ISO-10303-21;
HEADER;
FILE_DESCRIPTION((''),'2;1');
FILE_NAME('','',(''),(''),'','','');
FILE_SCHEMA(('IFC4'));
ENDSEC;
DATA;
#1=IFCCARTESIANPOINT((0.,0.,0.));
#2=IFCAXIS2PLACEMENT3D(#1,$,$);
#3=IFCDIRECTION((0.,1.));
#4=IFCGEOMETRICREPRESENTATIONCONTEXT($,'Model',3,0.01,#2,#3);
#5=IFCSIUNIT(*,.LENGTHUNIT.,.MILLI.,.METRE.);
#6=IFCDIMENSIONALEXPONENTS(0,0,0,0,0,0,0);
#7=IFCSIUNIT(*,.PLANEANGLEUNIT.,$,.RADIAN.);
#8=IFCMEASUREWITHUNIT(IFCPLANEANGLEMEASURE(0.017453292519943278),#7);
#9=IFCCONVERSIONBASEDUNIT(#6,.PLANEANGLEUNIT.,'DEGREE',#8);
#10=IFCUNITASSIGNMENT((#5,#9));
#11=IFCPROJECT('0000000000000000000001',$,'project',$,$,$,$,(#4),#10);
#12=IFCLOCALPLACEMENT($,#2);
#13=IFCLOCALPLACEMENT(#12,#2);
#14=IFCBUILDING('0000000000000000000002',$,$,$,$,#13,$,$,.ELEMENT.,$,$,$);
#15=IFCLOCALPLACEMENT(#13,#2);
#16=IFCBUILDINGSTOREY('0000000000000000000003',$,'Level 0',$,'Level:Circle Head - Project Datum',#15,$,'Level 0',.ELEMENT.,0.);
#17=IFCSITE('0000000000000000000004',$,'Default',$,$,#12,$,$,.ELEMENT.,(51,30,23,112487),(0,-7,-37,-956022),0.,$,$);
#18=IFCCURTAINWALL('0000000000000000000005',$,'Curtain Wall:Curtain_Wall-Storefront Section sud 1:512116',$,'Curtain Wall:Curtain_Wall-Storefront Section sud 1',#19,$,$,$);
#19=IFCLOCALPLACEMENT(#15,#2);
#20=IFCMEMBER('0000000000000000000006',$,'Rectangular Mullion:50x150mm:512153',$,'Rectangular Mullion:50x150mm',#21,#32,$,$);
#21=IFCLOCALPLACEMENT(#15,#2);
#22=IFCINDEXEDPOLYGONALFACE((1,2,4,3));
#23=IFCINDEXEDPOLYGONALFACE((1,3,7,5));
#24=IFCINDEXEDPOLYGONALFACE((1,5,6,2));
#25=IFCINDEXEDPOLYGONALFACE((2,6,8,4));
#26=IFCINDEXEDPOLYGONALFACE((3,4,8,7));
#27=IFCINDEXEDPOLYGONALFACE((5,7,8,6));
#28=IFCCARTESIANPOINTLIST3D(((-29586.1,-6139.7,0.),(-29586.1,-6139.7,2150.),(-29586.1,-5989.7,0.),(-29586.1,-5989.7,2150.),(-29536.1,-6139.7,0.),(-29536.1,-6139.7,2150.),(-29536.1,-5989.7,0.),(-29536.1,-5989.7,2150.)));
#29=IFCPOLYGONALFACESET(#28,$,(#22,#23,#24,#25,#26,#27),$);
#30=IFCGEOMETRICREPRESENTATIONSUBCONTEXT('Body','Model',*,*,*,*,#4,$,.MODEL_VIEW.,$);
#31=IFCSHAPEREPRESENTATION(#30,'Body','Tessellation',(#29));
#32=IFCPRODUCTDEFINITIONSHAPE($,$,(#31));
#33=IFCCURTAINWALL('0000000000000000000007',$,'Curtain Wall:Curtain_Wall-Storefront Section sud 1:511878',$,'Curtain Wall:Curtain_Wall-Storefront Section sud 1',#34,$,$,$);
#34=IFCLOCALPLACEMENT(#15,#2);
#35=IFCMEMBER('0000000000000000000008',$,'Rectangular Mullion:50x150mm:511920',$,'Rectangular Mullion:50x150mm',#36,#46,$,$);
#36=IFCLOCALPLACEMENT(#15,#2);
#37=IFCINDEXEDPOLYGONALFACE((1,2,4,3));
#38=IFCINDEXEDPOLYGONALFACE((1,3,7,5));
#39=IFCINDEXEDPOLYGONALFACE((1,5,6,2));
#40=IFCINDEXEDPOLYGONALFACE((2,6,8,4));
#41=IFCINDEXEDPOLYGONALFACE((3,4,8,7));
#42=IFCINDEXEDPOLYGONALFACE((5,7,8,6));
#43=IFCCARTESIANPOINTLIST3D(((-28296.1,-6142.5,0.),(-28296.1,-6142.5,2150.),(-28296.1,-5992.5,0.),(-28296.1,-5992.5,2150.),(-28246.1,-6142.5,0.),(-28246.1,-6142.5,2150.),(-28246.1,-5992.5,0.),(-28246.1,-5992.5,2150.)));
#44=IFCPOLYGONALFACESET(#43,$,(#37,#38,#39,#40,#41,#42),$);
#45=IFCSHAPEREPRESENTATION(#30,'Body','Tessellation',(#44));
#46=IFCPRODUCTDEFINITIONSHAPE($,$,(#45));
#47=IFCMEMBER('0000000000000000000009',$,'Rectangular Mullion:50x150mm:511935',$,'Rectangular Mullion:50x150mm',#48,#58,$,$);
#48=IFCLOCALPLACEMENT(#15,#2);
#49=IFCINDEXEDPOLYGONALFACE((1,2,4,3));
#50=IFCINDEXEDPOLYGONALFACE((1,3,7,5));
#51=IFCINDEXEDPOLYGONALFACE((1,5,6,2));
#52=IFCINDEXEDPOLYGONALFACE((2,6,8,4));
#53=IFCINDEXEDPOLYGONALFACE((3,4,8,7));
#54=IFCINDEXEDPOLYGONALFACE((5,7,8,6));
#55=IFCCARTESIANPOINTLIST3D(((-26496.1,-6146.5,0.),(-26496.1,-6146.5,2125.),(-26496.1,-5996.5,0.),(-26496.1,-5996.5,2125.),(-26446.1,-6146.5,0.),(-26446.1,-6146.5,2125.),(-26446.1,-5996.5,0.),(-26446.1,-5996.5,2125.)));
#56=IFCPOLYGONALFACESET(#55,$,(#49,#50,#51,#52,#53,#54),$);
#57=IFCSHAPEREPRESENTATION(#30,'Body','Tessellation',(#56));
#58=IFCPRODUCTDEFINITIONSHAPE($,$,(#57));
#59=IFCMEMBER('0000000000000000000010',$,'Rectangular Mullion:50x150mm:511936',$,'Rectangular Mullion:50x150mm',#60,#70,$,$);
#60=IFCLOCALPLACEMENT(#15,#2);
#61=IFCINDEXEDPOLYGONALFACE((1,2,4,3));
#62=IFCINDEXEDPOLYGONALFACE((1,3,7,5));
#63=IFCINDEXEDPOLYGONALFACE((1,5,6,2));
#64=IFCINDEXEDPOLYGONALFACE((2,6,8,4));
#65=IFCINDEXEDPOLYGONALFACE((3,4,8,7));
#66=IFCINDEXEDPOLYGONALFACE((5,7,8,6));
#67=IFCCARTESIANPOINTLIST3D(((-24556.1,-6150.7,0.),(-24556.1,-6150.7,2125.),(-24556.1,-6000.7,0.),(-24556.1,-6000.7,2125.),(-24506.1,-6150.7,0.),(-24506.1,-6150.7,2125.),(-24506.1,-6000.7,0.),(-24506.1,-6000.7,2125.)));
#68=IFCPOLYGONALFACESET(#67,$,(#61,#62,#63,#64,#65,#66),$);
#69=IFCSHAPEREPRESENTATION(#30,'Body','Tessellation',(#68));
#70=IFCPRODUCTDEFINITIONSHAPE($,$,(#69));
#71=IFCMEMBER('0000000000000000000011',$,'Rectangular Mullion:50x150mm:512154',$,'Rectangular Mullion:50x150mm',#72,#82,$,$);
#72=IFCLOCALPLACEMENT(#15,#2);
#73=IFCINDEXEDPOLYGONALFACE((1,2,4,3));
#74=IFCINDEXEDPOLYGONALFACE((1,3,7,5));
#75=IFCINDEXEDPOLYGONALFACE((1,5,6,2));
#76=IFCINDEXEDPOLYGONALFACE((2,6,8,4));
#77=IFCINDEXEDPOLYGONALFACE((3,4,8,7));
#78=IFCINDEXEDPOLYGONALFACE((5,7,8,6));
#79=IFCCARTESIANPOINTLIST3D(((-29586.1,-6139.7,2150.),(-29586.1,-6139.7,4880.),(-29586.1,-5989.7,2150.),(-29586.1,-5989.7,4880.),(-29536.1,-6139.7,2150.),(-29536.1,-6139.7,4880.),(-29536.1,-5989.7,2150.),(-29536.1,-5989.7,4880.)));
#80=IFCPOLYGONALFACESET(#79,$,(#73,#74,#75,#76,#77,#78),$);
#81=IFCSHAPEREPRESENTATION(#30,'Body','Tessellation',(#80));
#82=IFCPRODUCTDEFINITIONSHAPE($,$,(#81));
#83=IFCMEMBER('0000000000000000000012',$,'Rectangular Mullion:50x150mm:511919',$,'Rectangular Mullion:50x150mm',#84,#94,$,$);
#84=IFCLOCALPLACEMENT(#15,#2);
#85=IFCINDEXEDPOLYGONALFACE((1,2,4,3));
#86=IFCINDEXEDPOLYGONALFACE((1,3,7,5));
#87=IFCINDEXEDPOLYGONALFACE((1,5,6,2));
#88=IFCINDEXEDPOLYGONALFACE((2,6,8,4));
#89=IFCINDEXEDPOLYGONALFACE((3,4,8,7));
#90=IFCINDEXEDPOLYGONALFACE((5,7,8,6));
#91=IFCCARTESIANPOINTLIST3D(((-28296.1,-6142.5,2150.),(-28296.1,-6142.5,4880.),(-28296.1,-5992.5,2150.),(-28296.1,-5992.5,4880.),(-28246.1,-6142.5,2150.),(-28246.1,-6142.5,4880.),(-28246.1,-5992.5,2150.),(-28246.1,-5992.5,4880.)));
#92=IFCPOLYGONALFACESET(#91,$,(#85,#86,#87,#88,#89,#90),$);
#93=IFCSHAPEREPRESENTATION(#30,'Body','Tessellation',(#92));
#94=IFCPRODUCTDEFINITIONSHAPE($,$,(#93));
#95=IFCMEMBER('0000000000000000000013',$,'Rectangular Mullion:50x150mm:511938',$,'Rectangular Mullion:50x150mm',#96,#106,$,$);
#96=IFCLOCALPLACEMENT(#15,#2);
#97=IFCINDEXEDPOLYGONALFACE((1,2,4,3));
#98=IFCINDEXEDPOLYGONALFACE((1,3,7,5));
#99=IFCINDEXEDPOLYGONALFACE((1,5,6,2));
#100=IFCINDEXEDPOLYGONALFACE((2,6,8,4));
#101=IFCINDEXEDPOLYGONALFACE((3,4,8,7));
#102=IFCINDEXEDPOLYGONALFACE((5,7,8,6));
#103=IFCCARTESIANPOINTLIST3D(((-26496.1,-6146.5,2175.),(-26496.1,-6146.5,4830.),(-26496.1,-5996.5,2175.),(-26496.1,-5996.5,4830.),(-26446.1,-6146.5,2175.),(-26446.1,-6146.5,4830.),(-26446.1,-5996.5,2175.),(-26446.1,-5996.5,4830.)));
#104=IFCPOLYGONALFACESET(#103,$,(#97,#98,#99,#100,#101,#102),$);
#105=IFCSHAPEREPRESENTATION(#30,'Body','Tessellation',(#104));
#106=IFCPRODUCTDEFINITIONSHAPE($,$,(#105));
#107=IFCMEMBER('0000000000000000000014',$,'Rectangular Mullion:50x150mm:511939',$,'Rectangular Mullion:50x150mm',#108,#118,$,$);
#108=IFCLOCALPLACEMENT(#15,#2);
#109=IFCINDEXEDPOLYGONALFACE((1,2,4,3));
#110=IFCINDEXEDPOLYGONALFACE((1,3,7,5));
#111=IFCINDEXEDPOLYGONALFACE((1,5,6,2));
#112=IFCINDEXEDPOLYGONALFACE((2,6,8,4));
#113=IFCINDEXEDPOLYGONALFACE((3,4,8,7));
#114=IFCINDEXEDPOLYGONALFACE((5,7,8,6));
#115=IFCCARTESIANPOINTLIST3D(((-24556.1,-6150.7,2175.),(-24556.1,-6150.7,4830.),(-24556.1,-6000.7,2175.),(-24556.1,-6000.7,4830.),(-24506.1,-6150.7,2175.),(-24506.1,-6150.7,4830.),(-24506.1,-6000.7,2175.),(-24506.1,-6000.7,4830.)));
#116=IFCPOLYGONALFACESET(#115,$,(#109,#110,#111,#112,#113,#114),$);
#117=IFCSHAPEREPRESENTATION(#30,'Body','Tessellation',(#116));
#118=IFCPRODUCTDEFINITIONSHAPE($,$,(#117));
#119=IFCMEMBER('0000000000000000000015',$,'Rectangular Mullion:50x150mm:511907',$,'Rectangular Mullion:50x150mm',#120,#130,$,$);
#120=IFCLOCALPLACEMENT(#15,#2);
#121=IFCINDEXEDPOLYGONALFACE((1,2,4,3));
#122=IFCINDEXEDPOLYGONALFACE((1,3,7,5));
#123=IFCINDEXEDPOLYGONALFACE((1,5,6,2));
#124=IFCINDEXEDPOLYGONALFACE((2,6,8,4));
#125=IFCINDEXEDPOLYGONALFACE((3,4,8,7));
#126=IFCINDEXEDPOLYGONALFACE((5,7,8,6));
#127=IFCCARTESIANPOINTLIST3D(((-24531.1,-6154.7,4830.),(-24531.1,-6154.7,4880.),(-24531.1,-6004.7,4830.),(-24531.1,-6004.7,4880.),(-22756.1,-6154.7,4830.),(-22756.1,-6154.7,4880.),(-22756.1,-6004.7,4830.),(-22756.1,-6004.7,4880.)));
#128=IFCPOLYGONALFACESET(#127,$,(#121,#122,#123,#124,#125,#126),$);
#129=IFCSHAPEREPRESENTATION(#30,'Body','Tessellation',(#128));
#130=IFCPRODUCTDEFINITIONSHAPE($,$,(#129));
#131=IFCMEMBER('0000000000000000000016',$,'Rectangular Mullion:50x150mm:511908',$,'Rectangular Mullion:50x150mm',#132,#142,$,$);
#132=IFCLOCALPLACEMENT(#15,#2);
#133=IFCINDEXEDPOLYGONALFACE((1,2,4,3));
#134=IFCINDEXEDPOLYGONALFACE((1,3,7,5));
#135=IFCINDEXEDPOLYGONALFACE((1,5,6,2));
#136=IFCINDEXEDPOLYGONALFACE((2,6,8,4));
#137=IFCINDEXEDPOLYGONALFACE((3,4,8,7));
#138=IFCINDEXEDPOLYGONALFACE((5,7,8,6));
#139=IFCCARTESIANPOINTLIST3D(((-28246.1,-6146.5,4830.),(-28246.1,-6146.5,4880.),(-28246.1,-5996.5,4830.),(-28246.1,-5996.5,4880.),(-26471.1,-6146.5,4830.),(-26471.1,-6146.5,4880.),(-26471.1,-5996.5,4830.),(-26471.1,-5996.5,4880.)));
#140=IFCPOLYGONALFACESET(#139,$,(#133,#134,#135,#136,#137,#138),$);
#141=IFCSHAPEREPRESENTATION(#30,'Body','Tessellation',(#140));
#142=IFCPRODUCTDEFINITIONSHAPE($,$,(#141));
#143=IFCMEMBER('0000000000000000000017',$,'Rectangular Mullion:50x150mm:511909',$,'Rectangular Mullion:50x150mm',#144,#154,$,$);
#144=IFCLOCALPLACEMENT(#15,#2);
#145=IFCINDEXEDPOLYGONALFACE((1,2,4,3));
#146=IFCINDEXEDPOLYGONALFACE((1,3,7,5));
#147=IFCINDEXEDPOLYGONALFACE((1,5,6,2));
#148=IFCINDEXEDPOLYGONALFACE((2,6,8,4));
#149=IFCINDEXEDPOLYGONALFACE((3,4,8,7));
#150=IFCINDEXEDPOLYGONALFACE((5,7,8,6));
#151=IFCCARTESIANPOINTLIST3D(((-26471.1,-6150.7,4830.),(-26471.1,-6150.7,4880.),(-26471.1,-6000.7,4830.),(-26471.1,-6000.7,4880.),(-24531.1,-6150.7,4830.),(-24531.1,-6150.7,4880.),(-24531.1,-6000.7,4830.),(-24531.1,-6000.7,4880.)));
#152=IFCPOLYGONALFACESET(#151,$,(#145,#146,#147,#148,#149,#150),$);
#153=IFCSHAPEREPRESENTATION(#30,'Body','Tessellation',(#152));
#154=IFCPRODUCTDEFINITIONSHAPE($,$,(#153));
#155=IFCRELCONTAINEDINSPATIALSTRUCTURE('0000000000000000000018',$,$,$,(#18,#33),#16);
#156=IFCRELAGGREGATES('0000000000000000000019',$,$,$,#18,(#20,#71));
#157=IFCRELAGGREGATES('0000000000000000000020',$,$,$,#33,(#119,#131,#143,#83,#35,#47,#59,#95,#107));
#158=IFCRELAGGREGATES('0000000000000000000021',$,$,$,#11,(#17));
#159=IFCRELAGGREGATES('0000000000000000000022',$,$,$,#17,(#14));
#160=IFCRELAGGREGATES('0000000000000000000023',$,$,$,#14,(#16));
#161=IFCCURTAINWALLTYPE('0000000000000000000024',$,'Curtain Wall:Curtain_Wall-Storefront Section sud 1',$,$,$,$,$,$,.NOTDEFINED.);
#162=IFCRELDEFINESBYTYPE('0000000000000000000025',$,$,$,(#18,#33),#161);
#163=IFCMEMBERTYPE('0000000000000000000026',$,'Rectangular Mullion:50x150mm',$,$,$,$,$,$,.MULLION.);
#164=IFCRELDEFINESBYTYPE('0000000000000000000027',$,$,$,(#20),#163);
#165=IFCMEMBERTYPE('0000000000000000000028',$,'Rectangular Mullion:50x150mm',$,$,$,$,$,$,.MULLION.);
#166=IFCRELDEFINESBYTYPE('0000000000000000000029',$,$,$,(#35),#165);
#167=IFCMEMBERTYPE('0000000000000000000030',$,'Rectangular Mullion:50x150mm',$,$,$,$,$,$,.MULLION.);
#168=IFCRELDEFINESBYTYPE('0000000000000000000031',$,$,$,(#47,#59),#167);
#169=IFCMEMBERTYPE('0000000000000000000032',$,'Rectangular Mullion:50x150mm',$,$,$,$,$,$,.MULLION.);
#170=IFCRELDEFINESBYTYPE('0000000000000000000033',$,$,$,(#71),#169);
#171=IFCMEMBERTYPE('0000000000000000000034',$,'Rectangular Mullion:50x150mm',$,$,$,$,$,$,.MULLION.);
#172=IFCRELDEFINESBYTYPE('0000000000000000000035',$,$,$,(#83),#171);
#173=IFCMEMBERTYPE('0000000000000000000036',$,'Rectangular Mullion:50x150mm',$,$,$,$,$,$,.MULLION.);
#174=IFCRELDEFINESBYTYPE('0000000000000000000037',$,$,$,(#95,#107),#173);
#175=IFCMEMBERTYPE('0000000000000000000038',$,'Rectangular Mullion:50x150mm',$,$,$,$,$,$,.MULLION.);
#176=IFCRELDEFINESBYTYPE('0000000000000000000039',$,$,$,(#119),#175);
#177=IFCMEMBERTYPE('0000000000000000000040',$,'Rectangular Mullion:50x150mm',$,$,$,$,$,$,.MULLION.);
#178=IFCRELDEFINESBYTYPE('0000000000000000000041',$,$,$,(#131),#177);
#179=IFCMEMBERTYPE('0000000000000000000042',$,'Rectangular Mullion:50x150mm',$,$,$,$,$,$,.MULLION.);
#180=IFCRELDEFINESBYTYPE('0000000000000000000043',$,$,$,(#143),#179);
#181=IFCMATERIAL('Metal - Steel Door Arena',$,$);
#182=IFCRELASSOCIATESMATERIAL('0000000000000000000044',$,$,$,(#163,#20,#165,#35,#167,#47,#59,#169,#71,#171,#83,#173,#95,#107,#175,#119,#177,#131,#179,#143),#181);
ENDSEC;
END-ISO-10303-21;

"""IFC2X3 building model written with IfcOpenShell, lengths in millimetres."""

from ifc_helpers import new_model, entity, si_unit, converted_unit, direction, frame, origin, origin_2d_with_axis, place, context, subcontext, project, spatial, rectangle, extrude, source, transform, mapped, material, type_object, type_shapes, element, aggregate, save


model = new_model("IFC2X3")

# Units and contexts
model_context = context("Model", 3, precision=0.01, world=origin(), true_north=direction((0.0, 1.0)))
body_context = subcontext(model_context, "Body", "Model", "MODEL_VIEW")
ifc_project = project(units=[si_unit("LENGTHUNIT", "METRE", prefix="MILLI"), converted_unit("PLANEANGLEUNIT", "DEGREE", entity("IfcPlaneAngleMeasure", 0.017453292519943278), si_unit("PLANEANGLEUNIT", "RADIAN"), dimensions=[0, 0, 0, 0, 0, 0, 0])], contexts=[model_context])

# Site, building, storey
site_placement = place(None, origin())
site = spatial("IfcSite", under=ifc_project, at=site_placement, Name="Default", CompositionType="ELEMENT", RefLatitude=(51, 30, 23, 112487), RefLongitude=(0, -7, -37, -956022), RefElevation=0.0)
building_placement = place(site_placement, origin())
building = spatial("IfcBuilding", under=site, at=building_placement, CompositionType="ELEMENT")
storey_placement = place(building_placement, origin())
storey = spatial("IfcBuildingStorey", under=building, at=storey_placement, Name="Level 0", ObjectType="Level:Circle Head - Project Datum", LongName="Level 0", CompositionType="ELEMENT", Elevation=0.0)

# Curtain wall, member
curtain_wall_type = type_object("IfcCurtainWallType", Name="Curtain Wall:Curtain_Wall-Storefront Section sud 1", PredefinedType="NOTDEFINED")
curtain_wall_1_placement = place(storey_placement, origin())
curtain_wall_1 = element("IfcCurtainWall", 1, at=curtain_wall_1_placement, inside=storey, type_object=curtain_wall_type, Name="Curtain Wall:Curtain_Wall-Storefront Section sud 1:512116", ObjectType="Curtain Wall:Curtain_Wall-Storefront Section sud 1")
ifc_material_1 = material(Name="Metal - Steel Door Arena")
member_type_1 = type_object("IfcMemberType", Name="Rectangular Mullion:50x150mm", PredefinedType="MULLION", material=ifc_material_1)
shared_shape_1 = source(origin(), body_context, "Body", "SweptSolid", [
    extrude(rectangle(XDim=50.0, YDim=150.0, at=origin_2d_with_axis()), frame((-25.0, 0.0, -2150.0), z_axis=(0.0, 0.0, 1.0), x_axis=(-1.0, 0.0, 0.0)), (0.0, 0.0, 1.0), 2150.0),
])
type_shapes(member_type_1, [shared_shape_1])
member_1_placement = place(curtain_wall_1_placement, frame((-29536.1, -6064.7, 0.0), z_axis=(0.0, 0.0, -1.0), x_axis=(1.0, 0.0, 0.0)))
member_1 = element("IfcMember", 2, at=member_1_placement, type_object=member_type_1, material=ifc_material_1, Name="Rectangular Mullion:50x150mm:512153", ObjectType="Rectangular Mullion:50x150mm", context=body_context, shape_type="MappedRepresentation", body=[
    mapped(shared_shape_1, transform((0.0, 0.0, 0.0), scale=1.0)),
])

# Curtain wall, members
curtain_wall_2_placement = place(storey_placement, origin())
curtain_wall_2 = element("IfcCurtainWall", 3, at=curtain_wall_2_placement, inside=storey, type_object=curtain_wall_type, Name="Curtain Wall:Curtain_Wall-Storefront Section sud 1:511878", ObjectType="Curtain Wall:Curtain_Wall-Storefront Section sud 1")
member_type_2 = type_object("IfcMemberType", Name="Rectangular Mullion:50x150mm", PredefinedType="MULLION", material=ifc_material_1)
shared_shape_2 = source(origin(), body_context, "Body", "SweptSolid", [
    extrude(rectangle(XDim=50.0, YDim=150.0, at=origin_2d_with_axis()), frame((-25.0, 0.0, -2150.0), z_axis=(0.0, 0.0, 1.0), x_axis=(-1.0, 0.0, 0.0)), (0.0, 0.0, 1.0), 2150.0),
])
type_shapes(member_type_2, [shared_shape_2])
member_2_placement = place(curtain_wall_2_placement, frame((-28296.1, -6067.5, 2150.0), z_axis=(0.0, 0.0, 1.0), x_axis=(-1.0, 0.0, 0.0)))
member_2 = element("IfcMember", 4, at=member_2_placement, type_object=member_type_2, material=ifc_material_1, Name="Rectangular Mullion:50x150mm:511920", ObjectType="Rectangular Mullion:50x150mm", context=body_context, shape_type="MappedRepresentation", body=[
    mapped(shared_shape_2, transform((0.0, 0.0, 0.0), scale=1.0)),
])
member_type_3 = type_object("IfcMemberType", Name="Rectangular Mullion:50x150mm", PredefinedType="MULLION", material=ifc_material_1)
shared_shape_3 = source(origin(), body_context, "Body", "SweptSolid", [
    extrude(rectangle(XDim=50.0, YDim=150.0, at=origin_2d_with_axis()), frame((0.0, 0.0, -2125.0), z_axis=(0.0, 0.0, 1.0), x_axis=(-1.0, 0.0, 0.0)), (0.0, 0.0, 1.0), 2125.0),
])
type_shapes(member_type_3, [shared_shape_3])
member_3_placement = place(curtain_wall_2_placement, frame((-26471.1, -6071.5, 0.0), z_axis=(0.0, 0.0, -1.0), x_axis=(1.0, 0.0, 0.0)))
member_3 = element("IfcMember", 5, at=member_3_placement, type_object=member_type_3, material=ifc_material_1, Name="Rectangular Mullion:50x150mm:511935", ObjectType="Rectangular Mullion:50x150mm", context=body_context, shape_type="MappedRepresentation", body=[
    mapped(shared_shape_3, transform((0.0, 0.0, 0.0), scale=1.0)),
])
member_4_placement = place(curtain_wall_2_placement, frame((-24531.1, -6075.7, 0.0), z_axis=(0.0, 0.0, -1.0), x_axis=(1.0, 0.0, 0.0)))
member_4 = element("IfcMember", 6, at=member_4_placement, type_object=member_type_3, material=ifc_material_1, Name="Rectangular Mullion:50x150mm:511936", ObjectType="Rectangular Mullion:50x150mm", context=body_context, shape_type="MappedRepresentation", body=[
    mapped(shared_shape_3, transform((0.0, 0.0, 0.0), scale=1.0)),
])

# Members
member_type_4 = type_object("IfcMemberType", Name="Rectangular Mullion:50x150mm", PredefinedType="MULLION", material=ifc_material_1)
shared_shape_4 = source(origin(), body_context, "Body", "SweptSolid", [
    extrude(rectangle(XDim=50.0, YDim=150.0, at=origin_2d_with_axis()), frame((-25.0, 0.0, -2730.0), z_axis=(0.0, 0.0, 1.0), x_axis=(-1.0, 0.0, 0.0)), (0.0, 0.0, 1.0), 2730.0),
])
type_shapes(member_type_4, [shared_shape_4])
member_5_placement = place(curtain_wall_1_placement, frame((-29536.1, -6064.7, 2150.0), z_axis=(0.0, 0.0, -1.0), x_axis=(1.0, 0.0, 0.0)))
member_5 = element("IfcMember", 7, at=member_5_placement, type_object=member_type_4, material=ifc_material_1, Name="Rectangular Mullion:50x150mm:512154", ObjectType="Rectangular Mullion:50x150mm", context=body_context, shape_type="MappedRepresentation", body=[
    mapped(shared_shape_4, transform((0.0, 0.0, 0.0), scale=1.0)),
])
aggregate(curtain_wall_1, [member_1, member_5])
member_type_5 = type_object("IfcMemberType", Name="Rectangular Mullion:50x150mm", PredefinedType="MULLION", material=ifc_material_1)
shared_shape_5 = source(origin(), body_context, "Body", "SweptSolid", [
    extrude(rectangle(XDim=50.0, YDim=150.0, at=origin_2d_with_axis()), frame((-25.0, 0.0, -2730.0), z_axis=(0.0, 0.0, 1.0), x_axis=(-1.0, 0.0, 0.0)), (0.0, 0.0, 1.0), 2730.0),
])
type_shapes(member_type_5, [shared_shape_5])
member_6_placement = place(curtain_wall_2_placement, frame((-28296.1, -6067.5, 4880.0), z_axis=(0.0, 0.0, 1.0), x_axis=(-1.0, 0.0, 0.0)))
member_6 = element("IfcMember", 8, at=member_6_placement, type_object=member_type_5, material=ifc_material_1, Name="Rectangular Mullion:50x150mm:511919", ObjectType="Rectangular Mullion:50x150mm", context=body_context, shape_type="MappedRepresentation", body=[
    mapped(shared_shape_5, transform((0.0, 0.0, 0.0), scale=1.0)),
])
member_type_6 = type_object("IfcMemberType", Name="Rectangular Mullion:50x150mm", PredefinedType="MULLION", material=ifc_material_1)
shared_shape_6 = source(origin(), body_context, "Body", "SweptSolid", [
    extrude(rectangle(XDim=50.0, YDim=150.0, at=origin_2d_with_axis()), frame((0.0, 0.0, -2655.0), z_axis=(0.0, 0.0, 1.0), x_axis=(-1.0, 0.0, 0.0)), (0.0, 0.0, 1.0), 2655.0),
])
type_shapes(member_type_6, [shared_shape_6])
member_7_placement = place(curtain_wall_2_placement, frame((-26471.1, -6071.5, 2175.0), z_axis=(0.0, 0.0, -1.0), x_axis=(1.0, 0.0, 0.0)))
member_7 = element("IfcMember", 9, at=member_7_placement, type_object=member_type_6, material=ifc_material_1, Name="Rectangular Mullion:50x150mm:511938", ObjectType="Rectangular Mullion:50x150mm", context=body_context, shape_type="MappedRepresentation", body=[
    mapped(shared_shape_6, transform((0.0, 0.0, 0.0), scale=1.0)),
])
member_8_placement = place(curtain_wall_2_placement, frame((-24531.1, -6075.7, 2175.0), z_axis=(0.0, 0.0, -1.0), x_axis=(1.0, 0.0, 0.0)))
member_8 = element("IfcMember", 10, at=member_8_placement, type_object=member_type_6, material=ifc_material_1, Name="Rectangular Mullion:50x150mm:511939", ObjectType="Rectangular Mullion:50x150mm", context=body_context, shape_type="MappedRepresentation", body=[
    mapped(shared_shape_6, transform((0.0, 0.0, 0.0), scale=1.0)),
])
member_type_7 = type_object("IfcMemberType", Name="Rectangular Mullion:50x150mm", PredefinedType="MULLION", material=ifc_material_1)
shared_shape_7 = source(origin(), body_context, "Body", "SweptSolid", [
    extrude(rectangle(XDim=50.0, YDim=150.0, at=origin_2d_with_axis()), frame((-25.0, 0.0, -1775.0), z_axis=(0.0, 0.0, 1.0), x_axis=(-1.0, 0.0, 0.0)), (0.0, 0.0, 1.0), 1775.0),
])
type_shapes(member_type_7, [shared_shape_7])
member_9_placement = place(curtain_wall_2_placement, frame((-22756.1, -6079.7, 4880.0), z_axis=(1.0, 0.0, 0.0), x_axis=(0.0, 0.0, 1.0)))
member_9 = element("IfcMember", 11, at=member_9_placement, type_object=member_type_7, material=ifc_material_1, Name="Rectangular Mullion:50x150mm:511907", ObjectType="Rectangular Mullion:50x150mm", context=body_context, shape_type="MappedRepresentation", body=[
    mapped(shared_shape_7, transform((0.0, 0.0, 0.0), scale=1.0)),
])
member_type_8 = type_object("IfcMemberType", Name="Rectangular Mullion:50x150mm", PredefinedType="MULLION", material=ifc_material_1)
shared_shape_8 = source(origin(), body_context, "Body", "SweptSolid", [
    extrude(rectangle(XDim=50.0, YDim=150.0, at=origin_2d_with_axis()), frame((-25.0, 0.0, -1775.0), z_axis=(0.0, 0.0, 1.0), x_axis=(-1.0, 0.0, 0.0)), (0.0, 0.0, 1.0), 1775.0),
])
type_shapes(member_type_8, [shared_shape_8])
member_10_placement = place(curtain_wall_2_placement, frame((-26471.1, -6071.5, 4880.0), z_axis=(1.0, 0.0, 0.0), x_axis=(0.0, 0.0, 1.0)))
member_10 = element("IfcMember", 12, at=member_10_placement, type_object=member_type_8, material=ifc_material_1, Name="Rectangular Mullion:50x150mm:511908", ObjectType="Rectangular Mullion:50x150mm", context=body_context, shape_type="MappedRepresentation", body=[
    mapped(shared_shape_8, transform((0.0, 0.0, 0.0), scale=1.0)),
])
member_type_9 = type_object("IfcMemberType", Name="Rectangular Mullion:50x150mm", PredefinedType="MULLION", material=ifc_material_1)
shared_shape_9 = source(origin(), body_context, "Body", "SweptSolid", [
    extrude(rectangle(XDim=50.0, YDim=150.0, at=origin_2d_with_axis()), frame((-25.0, 0.0, -1940.0), z_axis=(0.0, 0.0, 1.0), x_axis=(-1.0, 0.0, 0.0)), (0.0, 0.0, 1.0), 1940.0),
])
type_shapes(member_type_9, [shared_shape_9])
member_11_placement = place(curtain_wall_2_placement, frame((-24531.1, -6075.7, 4880.0), z_axis=(1.0, 0.0, 0.0), x_axis=(0.0, 0.0, 1.0)))
member_11 = element("IfcMember", 13, at=member_11_placement, type_object=member_type_9, material=ifc_material_1, Name="Rectangular Mullion:50x150mm:511909", ObjectType="Rectangular Mullion:50x150mm", context=body_context, shape_type="MappedRepresentation", body=[
    mapped(shared_shape_9, transform((0.0, 0.0, 0.0), scale=1.0)),
])

aggregate(curtain_wall_2, [member_9, member_10, member_11, member_6, member_2, member_3, member_4, member_7, member_8])

save(model, "model.ifc")
